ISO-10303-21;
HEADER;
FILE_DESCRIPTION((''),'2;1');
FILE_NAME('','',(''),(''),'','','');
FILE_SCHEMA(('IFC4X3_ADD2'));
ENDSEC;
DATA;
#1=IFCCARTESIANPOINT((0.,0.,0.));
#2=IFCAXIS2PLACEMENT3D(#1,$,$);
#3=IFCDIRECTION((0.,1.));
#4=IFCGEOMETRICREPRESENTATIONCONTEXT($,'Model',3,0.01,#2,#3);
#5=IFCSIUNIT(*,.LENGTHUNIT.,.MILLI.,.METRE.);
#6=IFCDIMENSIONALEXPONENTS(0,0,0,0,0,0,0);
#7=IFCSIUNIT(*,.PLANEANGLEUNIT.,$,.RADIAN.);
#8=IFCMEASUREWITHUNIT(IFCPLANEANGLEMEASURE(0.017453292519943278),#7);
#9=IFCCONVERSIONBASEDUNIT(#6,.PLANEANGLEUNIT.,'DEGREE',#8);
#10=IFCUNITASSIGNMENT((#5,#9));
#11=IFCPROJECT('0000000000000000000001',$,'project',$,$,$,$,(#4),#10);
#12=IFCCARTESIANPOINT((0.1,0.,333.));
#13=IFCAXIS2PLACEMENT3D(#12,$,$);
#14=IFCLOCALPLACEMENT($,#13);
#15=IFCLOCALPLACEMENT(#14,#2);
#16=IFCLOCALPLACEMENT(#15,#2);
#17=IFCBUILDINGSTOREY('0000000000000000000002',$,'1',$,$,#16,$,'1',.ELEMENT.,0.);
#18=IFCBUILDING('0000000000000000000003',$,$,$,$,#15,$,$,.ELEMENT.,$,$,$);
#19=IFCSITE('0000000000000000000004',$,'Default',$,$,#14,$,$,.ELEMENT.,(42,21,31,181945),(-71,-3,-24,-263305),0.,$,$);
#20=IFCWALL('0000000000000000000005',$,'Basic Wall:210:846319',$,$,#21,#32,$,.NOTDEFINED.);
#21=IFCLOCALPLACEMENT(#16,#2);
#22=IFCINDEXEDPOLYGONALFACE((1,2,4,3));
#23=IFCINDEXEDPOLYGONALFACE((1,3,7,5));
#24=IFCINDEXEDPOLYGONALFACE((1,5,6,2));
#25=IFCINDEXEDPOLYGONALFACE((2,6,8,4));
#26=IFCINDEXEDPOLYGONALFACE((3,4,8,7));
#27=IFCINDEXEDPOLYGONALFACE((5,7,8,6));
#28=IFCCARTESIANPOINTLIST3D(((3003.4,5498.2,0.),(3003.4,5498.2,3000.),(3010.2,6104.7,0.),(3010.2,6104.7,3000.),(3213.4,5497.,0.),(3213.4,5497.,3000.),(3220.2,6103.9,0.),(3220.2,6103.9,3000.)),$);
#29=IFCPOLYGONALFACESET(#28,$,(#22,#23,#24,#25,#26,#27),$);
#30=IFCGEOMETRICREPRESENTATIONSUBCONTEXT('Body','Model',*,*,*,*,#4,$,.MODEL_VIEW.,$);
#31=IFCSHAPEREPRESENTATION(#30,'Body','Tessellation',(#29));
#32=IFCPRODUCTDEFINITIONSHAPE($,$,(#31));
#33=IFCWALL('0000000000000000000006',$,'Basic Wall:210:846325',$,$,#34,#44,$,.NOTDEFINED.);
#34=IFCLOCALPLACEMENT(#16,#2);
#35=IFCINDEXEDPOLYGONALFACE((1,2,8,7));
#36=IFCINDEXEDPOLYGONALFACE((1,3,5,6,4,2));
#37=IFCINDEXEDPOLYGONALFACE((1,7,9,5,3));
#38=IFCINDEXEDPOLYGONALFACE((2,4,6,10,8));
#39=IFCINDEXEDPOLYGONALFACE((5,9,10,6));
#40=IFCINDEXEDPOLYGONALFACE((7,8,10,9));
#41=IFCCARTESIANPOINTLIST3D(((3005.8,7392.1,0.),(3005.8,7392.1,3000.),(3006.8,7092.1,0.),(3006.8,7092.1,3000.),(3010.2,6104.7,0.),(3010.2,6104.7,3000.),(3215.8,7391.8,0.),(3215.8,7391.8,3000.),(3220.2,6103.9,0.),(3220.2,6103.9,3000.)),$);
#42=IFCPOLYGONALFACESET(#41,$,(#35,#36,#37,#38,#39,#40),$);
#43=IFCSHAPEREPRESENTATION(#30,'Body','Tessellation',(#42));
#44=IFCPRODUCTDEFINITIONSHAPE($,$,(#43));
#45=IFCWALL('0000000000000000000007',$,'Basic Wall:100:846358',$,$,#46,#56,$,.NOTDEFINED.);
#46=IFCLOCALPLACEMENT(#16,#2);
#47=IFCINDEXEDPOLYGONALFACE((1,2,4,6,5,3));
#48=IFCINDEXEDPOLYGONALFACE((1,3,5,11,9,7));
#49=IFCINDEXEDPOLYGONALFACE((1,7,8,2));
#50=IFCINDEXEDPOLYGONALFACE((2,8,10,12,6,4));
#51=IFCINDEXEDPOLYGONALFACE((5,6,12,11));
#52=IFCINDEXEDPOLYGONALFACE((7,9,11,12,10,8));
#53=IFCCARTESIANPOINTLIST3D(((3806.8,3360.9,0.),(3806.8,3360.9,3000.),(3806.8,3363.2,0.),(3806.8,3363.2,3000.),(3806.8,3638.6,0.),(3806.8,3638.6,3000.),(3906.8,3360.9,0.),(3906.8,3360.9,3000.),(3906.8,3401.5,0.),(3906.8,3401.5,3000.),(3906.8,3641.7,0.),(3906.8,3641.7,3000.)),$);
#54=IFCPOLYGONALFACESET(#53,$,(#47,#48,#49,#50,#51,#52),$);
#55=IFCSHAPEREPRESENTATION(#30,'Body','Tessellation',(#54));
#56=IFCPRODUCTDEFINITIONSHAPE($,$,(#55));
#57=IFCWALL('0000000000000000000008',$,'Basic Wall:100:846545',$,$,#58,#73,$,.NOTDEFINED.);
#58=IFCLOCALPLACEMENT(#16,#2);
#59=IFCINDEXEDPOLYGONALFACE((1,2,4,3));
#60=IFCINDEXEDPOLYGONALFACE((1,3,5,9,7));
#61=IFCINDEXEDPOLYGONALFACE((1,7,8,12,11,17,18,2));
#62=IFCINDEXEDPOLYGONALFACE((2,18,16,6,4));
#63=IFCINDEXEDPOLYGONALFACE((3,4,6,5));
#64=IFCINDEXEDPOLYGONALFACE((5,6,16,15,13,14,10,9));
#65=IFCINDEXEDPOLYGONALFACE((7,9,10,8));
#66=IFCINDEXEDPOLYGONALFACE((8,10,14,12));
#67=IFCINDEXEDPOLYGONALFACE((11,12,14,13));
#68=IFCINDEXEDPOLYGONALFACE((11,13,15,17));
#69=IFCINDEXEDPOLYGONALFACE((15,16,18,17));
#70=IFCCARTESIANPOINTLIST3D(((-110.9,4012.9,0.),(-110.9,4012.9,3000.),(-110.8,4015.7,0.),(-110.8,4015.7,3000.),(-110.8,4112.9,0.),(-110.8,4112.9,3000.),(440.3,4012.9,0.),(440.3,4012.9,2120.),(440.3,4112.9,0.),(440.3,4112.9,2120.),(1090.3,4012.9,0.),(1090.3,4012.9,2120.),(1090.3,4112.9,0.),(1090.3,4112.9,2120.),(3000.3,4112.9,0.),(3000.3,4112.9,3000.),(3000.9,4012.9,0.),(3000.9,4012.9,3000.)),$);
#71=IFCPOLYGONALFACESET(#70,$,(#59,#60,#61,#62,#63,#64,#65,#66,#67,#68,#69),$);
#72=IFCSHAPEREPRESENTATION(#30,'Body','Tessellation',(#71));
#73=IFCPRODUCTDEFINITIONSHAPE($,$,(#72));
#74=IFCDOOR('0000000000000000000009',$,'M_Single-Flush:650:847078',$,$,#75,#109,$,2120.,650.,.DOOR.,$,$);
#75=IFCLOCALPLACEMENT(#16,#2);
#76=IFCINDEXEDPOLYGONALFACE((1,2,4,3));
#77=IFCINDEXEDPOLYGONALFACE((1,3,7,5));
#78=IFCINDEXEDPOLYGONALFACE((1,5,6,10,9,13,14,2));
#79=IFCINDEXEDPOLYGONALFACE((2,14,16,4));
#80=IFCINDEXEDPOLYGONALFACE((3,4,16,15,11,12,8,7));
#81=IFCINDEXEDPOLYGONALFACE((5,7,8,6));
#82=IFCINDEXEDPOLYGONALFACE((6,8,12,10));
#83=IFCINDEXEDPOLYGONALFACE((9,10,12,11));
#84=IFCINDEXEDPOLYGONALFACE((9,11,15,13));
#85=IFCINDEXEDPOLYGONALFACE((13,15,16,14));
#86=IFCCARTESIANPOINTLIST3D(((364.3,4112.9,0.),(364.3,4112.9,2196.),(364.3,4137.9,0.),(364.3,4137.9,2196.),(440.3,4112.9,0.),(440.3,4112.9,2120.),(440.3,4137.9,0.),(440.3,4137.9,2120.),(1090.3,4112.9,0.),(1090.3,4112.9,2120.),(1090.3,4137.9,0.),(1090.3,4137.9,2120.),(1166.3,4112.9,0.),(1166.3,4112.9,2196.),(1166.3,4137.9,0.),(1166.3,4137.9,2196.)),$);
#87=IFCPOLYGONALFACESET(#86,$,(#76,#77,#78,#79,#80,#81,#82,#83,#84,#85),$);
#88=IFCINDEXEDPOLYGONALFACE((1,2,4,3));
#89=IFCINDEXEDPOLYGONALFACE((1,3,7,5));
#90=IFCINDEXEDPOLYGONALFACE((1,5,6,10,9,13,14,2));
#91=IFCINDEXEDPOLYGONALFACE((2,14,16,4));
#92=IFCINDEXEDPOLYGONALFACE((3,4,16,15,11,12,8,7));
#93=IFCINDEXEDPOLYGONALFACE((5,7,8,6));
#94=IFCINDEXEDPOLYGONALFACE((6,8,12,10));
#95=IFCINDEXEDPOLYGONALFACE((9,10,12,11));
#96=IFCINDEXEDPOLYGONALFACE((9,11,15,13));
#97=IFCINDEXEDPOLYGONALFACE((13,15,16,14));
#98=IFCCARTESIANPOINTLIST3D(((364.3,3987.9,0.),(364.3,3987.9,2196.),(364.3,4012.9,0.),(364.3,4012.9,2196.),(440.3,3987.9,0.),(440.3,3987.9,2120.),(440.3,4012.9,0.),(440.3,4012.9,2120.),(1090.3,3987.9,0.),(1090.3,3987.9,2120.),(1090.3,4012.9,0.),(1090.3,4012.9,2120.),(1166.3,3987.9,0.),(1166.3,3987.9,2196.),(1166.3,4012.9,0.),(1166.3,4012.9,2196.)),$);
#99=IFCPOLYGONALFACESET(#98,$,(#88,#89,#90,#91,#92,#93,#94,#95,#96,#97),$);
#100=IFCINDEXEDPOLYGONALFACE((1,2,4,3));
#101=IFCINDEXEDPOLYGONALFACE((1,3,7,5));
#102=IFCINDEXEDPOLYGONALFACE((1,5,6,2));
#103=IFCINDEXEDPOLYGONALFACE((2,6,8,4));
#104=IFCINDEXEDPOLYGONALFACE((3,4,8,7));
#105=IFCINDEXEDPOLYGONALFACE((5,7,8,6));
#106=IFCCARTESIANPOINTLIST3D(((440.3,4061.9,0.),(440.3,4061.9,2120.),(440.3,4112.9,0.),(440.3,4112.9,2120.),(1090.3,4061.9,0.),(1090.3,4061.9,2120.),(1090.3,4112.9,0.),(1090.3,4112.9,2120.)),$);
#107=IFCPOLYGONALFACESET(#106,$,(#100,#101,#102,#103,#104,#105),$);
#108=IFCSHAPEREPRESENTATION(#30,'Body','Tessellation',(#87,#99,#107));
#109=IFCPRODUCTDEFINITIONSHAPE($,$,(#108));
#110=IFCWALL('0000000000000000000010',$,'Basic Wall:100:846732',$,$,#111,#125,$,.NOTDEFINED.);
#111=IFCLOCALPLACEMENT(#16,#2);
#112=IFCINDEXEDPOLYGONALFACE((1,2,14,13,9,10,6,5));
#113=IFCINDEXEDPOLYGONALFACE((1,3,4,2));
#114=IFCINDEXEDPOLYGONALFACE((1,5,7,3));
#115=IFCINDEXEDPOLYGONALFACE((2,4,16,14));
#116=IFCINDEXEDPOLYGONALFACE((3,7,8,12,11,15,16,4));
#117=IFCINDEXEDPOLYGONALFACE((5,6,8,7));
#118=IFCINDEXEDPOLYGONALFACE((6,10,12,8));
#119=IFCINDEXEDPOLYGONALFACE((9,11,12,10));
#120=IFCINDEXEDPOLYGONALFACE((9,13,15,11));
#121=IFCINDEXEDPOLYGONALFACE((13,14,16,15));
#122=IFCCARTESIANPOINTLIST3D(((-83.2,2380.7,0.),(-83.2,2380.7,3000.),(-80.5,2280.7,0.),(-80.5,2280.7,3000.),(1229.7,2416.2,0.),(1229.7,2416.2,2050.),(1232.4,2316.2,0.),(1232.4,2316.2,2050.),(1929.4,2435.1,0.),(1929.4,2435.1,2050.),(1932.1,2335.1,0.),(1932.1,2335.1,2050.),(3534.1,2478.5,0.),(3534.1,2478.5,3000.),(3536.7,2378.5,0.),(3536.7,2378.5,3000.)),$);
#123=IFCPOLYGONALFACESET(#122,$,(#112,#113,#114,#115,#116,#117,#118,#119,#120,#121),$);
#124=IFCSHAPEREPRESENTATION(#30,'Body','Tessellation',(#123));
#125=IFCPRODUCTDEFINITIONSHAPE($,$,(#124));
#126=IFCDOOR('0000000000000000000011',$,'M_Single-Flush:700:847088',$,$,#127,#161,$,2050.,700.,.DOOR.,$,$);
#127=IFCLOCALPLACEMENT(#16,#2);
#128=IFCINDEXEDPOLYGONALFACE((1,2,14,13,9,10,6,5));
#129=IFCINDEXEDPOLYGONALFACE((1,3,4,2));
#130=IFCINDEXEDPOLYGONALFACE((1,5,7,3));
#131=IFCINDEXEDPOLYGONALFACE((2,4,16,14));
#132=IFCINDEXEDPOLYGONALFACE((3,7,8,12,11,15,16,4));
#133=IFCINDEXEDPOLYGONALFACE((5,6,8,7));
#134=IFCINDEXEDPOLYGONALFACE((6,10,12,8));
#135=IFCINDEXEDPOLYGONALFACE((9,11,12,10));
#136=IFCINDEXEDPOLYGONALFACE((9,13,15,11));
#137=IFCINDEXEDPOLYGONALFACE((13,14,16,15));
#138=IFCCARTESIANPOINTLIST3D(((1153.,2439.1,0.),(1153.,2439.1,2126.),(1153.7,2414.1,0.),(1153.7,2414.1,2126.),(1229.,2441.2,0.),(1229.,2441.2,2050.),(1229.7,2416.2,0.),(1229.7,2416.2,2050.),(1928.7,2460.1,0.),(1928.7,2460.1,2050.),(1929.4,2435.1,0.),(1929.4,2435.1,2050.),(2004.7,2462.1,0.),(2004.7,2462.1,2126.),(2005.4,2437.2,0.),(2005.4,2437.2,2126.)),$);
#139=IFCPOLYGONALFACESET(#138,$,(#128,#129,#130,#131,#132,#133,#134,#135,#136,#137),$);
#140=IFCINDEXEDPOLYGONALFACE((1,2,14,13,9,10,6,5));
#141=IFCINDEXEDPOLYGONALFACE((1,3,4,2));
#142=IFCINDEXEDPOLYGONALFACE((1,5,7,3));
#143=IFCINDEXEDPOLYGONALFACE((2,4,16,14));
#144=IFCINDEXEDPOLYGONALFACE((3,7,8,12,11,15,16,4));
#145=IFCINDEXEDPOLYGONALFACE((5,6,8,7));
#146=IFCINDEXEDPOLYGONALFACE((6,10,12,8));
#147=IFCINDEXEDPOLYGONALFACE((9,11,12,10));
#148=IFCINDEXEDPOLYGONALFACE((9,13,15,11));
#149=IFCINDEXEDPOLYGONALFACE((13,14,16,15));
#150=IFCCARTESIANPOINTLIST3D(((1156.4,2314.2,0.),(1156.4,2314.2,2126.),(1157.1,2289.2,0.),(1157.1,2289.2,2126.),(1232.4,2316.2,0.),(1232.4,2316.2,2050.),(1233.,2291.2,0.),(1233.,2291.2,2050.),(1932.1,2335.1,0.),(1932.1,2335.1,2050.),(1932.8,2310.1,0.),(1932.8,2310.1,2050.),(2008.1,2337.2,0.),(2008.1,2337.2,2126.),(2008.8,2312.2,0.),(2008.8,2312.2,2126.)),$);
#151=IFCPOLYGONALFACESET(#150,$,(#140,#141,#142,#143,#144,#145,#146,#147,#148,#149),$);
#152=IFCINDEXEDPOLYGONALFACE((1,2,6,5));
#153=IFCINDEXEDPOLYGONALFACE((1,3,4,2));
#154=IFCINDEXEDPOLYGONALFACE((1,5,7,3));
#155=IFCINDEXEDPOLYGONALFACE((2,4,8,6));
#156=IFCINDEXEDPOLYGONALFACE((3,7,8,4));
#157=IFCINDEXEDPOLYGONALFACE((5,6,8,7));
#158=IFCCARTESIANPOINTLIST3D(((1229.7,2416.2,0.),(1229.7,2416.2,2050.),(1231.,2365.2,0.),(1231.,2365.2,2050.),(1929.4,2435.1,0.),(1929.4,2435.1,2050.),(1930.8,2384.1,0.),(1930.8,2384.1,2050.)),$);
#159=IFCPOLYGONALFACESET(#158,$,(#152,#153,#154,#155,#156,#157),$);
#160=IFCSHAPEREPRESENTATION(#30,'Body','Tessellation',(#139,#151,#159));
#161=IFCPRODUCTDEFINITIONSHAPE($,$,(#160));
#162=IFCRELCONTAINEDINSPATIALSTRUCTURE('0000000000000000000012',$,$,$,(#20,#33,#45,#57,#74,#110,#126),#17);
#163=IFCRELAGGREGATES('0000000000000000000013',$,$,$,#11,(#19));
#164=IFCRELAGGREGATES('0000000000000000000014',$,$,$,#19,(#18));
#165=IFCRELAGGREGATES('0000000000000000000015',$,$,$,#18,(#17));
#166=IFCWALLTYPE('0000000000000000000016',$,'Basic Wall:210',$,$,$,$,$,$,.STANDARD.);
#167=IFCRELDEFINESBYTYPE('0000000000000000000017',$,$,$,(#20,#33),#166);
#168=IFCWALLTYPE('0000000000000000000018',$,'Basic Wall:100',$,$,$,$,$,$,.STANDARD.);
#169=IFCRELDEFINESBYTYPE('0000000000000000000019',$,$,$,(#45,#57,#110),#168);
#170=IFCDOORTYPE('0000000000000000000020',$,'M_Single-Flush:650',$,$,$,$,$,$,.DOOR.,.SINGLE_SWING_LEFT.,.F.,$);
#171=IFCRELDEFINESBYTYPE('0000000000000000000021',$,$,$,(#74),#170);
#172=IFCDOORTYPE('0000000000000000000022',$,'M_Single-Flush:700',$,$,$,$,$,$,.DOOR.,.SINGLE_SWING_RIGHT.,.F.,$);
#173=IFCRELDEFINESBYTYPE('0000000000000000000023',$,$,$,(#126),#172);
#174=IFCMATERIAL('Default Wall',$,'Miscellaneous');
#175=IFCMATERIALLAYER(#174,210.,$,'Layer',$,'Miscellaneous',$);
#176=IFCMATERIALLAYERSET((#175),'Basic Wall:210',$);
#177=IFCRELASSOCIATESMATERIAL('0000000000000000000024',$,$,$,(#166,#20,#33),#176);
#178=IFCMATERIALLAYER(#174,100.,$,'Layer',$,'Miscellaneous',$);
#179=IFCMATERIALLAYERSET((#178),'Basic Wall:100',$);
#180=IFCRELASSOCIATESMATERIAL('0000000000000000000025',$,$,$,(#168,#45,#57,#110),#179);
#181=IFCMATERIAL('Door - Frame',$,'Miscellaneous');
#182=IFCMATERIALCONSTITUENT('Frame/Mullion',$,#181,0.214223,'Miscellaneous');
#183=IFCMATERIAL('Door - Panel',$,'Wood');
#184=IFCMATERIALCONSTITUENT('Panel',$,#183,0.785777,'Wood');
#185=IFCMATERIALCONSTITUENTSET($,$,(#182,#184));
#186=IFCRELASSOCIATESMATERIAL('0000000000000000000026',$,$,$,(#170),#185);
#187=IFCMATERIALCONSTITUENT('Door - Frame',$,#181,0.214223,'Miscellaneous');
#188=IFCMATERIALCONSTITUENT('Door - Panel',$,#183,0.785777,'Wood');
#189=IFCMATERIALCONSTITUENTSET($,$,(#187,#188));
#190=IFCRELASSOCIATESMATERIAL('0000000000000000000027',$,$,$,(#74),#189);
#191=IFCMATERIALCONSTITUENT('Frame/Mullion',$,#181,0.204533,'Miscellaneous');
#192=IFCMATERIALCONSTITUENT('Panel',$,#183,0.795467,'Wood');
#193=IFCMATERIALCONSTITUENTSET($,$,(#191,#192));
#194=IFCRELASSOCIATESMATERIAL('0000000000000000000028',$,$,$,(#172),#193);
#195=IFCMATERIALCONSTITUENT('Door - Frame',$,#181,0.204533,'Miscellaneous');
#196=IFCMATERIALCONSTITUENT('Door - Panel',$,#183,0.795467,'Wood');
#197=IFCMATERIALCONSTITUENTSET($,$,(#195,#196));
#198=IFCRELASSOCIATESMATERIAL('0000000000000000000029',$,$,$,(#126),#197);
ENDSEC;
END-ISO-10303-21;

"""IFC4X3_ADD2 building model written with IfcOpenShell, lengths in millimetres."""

from ifc_helpers import new_model, entity, si_unit, converted_unit, direction, frame, frame_2d, origin, origin_2d_with_axis, place, context, subcontext, project, spatial, polyline, rectangle, outline, extrude, source, transform, mapped, material, layer, layer_set, constituent, constituent_set, type_object, type_shapes, element, fill, save


model = new_model("IFC4X3_ADD2")

# Units and contexts
model_context = context("Model", 3, precision=0.01, world=origin(), true_north=direction((0.0, 1.0)))
body_context = subcontext(model_context, "Body", "Model", "MODEL_VIEW")
ifc_project = project(units=[si_unit("LENGTHUNIT", "METRE", prefix="MILLI"), converted_unit("PLANEANGLEUNIT", "DEGREE", entity("IfcPlaneAngleMeasure", 0.017453292519943278), si_unit("PLANEANGLEUNIT", "RADIAN"), dimensions=[0, 0, 0, 0, 0, 0, 0])], contexts=[model_context])

# Site, building, storey
site_placement = place(None, frame((0.1, 0.0, 333.0)))
site = spatial("IfcSite", under=ifc_project, at=site_placement, Name="Default", CompositionType="ELEMENT", RefLatitude=(42, 21, 31, 181945), RefLongitude=(-71, -3, -24, -263305), RefElevation=0.0)
building_placement = place(site_placement, origin())
building = spatial("IfcBuilding", under=site, at=building_placement, CompositionType="ELEMENT")
storey_placement = place(building_placement, origin())
storey = spatial("IfcBuildingStorey", under=building, at=storey_placement, Name="1", LongName="1", CompositionType="ELEMENT", Elevation=0.0)

# Shared definitions
ifc_material_1 = material(Name="Default Wall", Category="Miscellaneous")

# Walls
ifc_layer_1 = layer(ifc_material_1, 210.0, Name="Layer", Category="Miscellaneous")
ifc_layer_set_1 = layer_set([ifc_layer_1], Name="Basic Wall:210")
wall_type_1 = type_object("IfcWallType", Name="Basic Wall:210", PredefinedType="STANDARD", material=ifc_layer_set_1)
wall_1_placement = place(storey_placement, frame((3115.2, 6105.1, 0.0), z_axis=(0.0, 0.0, 1.0), x_axis=(-0.011193, -0.999937, 0.0)))
element("IfcWall", 1, at=wall_1_placement, inside=storey, type_object=wall_type_1, material=ifc_layer_set_1, Name="Basic Wall:210:846319", PredefinedType="NOTDEFINED", context=body_context, shape_type="SweptSolid", body=[
    extrude(outline(polyline([(608.1, -105.0), (606.9, 105.0), (0.0, 105.0), (1.5, -105.0), (608.1, -105.0)])), origin(), (0.0, 0.0, 1.0), 3000.0),
])
wall_2_placement = place(storey_placement, frame((3110.8, 7392.5, 0.0), z_axis=(0.0, 0.0, 1.0), x_axis=(0.003397, -0.999994, 0.0)))
element("IfcWall", 2, at=wall_2_placement, inside=storey, type_object=wall_type_1, material=ifc_layer_set_1, Name="Basic Wall:210:846325", PredefinedType="NOTDEFINED", context=body_context, shape_type="SweptSolid", body=[
    extrude(outline(polyline([(1287.4, -105.0), (1288.9, 105.0), (1.0, 105.0), (0.0, -105.0), (300.0, -105.0), (1287.4, -105.0)])), origin(), (0.0, 0.0, 1.0), 3000.0),
])
ifc_layer_2 = layer(ifc_material_1, 100.0, Name="Layer", Category="Miscellaneous")
ifc_layer_set_2 = layer_set([ifc_layer_2], Name="Basic Wall:100")
wall_type_2 = type_object("IfcWallType", Name="Basic Wall:100", PredefinedType="STANDARD", material=ifc_layer_set_2)
wall_3_placement = place(storey_placement, frame((3856.8, 3360.9, 0.0), z_axis=(0.0, 0.0, 1.0), x_axis=(0.0, 1.0, 0.0)))
element("IfcWall", 3, at=wall_3_placement, inside=storey, type_object=wall_type_2, material=ifc_layer_set_2, Name="Basic Wall:100:846358", PredefinedType="NOTDEFINED", context=body_context, shape_type="SweptSolid", body=[
    extrude(outline(polyline([(280.7, -50.0), (277.6, 50.0), (2.3, 50.0), (0.0, 50.0), (0.0, -50.0), (40.6, -50.0), (280.7, -50.0)])), origin(), (0.0, 0.0, 1.0), 3000.0),
])

# Walls, openings, doors
wall_4_placement = place(storey_placement, frame((3000.9, 4062.9, 0.0), z_axis=(0.0, 0.0, 1.0), x_axis=(-1.0, 0.0, 0.0)))
wall_4 = element("IfcWall", 4, at=wall_4_placement, inside=storey, type_object=wall_type_2, material=ifc_layer_set_2, Name="Basic Wall:100:846545", PredefinedType="NOTDEFINED", context=body_context, shape_type="SweptSolid", body=[
    extrude(outline(polyline([(0.6, -50.0), (3111.7, -50.0), (3111.7, 47.1), (3111.8, 50.0), (0.0, 50.0), (0.6, -50.0)])), origin(), (0.0, 0.0, 1.0), 3000.0),
])
opening_1_placement = place(wall_4_placement, frame((2560.6, 50.0, 0.0)))
opening_1 = element("IfcOpeningElement", 5, at=opening_1_placement, cuts=wall_4, PredefinedType="OPENING", context=body_context, shape_type="SweptSolid", body=[
    extrude(rectangle(XDim=650.0, YDim=2120.0, at=frame_2d((1060.0, 325.0), x_axis=(0.0, -1.0))), frame((0.0, 0.0, 0.0), z_axis=(0.0, -1.0, 0.0), x_axis=(0.0, 0.0, 1.0)), (0.0, 0.0, 1.0), 100.0),
])
ifc_material_2 = material(Name="Door - Frame", Category="Miscellaneous")
ifc_constituent_1 = constituent(ifc_material_2, Name="Door - Frame", Category="Miscellaneous", fraction=0.214223)
ifc_material_3 = material(Name="Door - Panel", Category="Wood")
ifc_constituent_2 = constituent(ifc_material_3, Name="Door - Panel", Category="Wood", fraction=0.785777)
ifc_constituent_set_1 = constituent_set(constituents=[ifc_constituent_1, ifc_constituent_2])
ifc_constituent_3 = constituent(ifc_material_2, Name="Frame/Mullion", Category="Miscellaneous", fraction=0.214223)
ifc_constituent_4 = constituent(ifc_material_3, Name="Panel", Category="Wood", fraction=0.785777)
ifc_constituent_set_2 = constituent_set(constituents=[ifc_constituent_3, ifc_constituent_4])
door_type_1 = type_object("IfcDoorType", Name="M_Single-Flush:650", OperationType="SINGLE_SWING_LEFT", ParameterTakesPrecedence=False, PredefinedType="DOOR", material=ifc_constituent_set_2)
shared_shape_1 = source(origin(), body_context, "Body", "SweptSolid", [
    extrude(outline(polyline([(-401.0, -1117.0), (401.0, -1117.0), (401.0, 1079.0), (325.0, 1079.0), (325.0, -1041.0), (-325.0, -1041.0), (-325.0, 1079.0), (-401.0, 1079.0), (-401.0, -1117.0)])), frame((325.0, 125.0, 1079.0), z_axis=(0.0, -1.0, 0.0), x_axis=(-1.0, 0.0, 0.0)), (0.0, 0.0, 1.0), 25.0),
    extrude(outline(polyline([(-1117.0, -401.0), (1079.0, -401.0), (1079.0, -325.0), (-1041.0, -325.0), (-1041.0, 325.0), (1079.0, 325.0), (1079.0, 401.0), (-1117.0, 401.0), (-1117.0, -401.0)])), frame((325.0, 0.0, 1079.0), z_axis=(0.0, -1.0, 0.0), x_axis=(0.0, 0.0, -1.0)), (0.0, 0.0, 1.0), 25.0),
    extrude(rectangle(XDim=650.0, YDim=51.0, at=origin_2d_with_axis()), frame((325.0, 74.5, 0.0)), (0.0, 0.0, 1.0), 2120.0),
])
type_shapes(door_type_1, [shared_shape_1])
door_1_placement = place(opening_1_placement, frame((0.0, 0.0, 0.0), z_axis=(0.0, 0.0, 1.0), x_axis=(-1.0, 0.0, 0.0)))
door_1 = element("IfcDoor", 6, at=door_1_placement, inside=storey, type_object=door_type_1, material=ifc_constituent_set_1, Name="M_Single-Flush:650:847078", OverallHeight=2120.0, OverallWidth=650.0, PredefinedType="DOOR", context=body_context, shape_type="MappedRepresentation", body=[
    mapped(shared_shape_1, transform((0.0, 0.0, 0.0), scale=1.0)),
])
fill(opening_1, door_1)
wall_5_placement = place(storey_placement, frame((-81.8, 2330.7, 0.0), z_axis=(0.0, 0.0, 1.0), x_axis=(0.999635, 0.027022, 0.0)))
wall_5 = element("IfcWall", 7, at=wall_5_placement, inside=storey, type_object=wall_type_2, material=ifc_layer_set_2, Name="Basic Wall:100:846732", PredefinedType="NOTDEFINED", context=body_context, shape_type="SweptSolid", body=[
    extrude(outline(polyline([(0.0, -50.0), (3618.5, -50.0), (3618.6, 50.0), (3187.5, 50.0), (3087.5, 50.0), (0.0, 50.0), (0.0, -50.0)])), origin(), (0.0, 0.0, 1.0), 3000.0),
])
opening_2_placement = place(wall_5_placement, frame((1313.3, -50.0, 0.0)))
opening_2 = element("IfcOpeningElement", 8, at=opening_2_placement, cuts=wall_5, PredefinedType="OPENING", context=body_context, shape_type="SweptSolid", body=[
    extrude(rectangle(XDim=700.0, YDim=2050.0, at=frame_2d((1025.0, 350.0), x_axis=(0.0, 1.0))), frame((0.0, 0.0, 0.0), z_axis=(0.0, 1.0, 0.0), x_axis=(0.0, 0.0, 1.0)), (0.0, 0.0, 1.0), 100.0),
])
ifc_constituent_5 = constituent(ifc_material_2, Name="Door - Frame", Category="Miscellaneous", fraction=0.204533)
ifc_constituent_6 = constituent(ifc_material_3, Name="Door - Panel", Category="Wood", fraction=0.795467)
ifc_constituent_set_3 = constituent_set(constituents=[ifc_constituent_5, ifc_constituent_6])
ifc_constituent_7 = constituent(ifc_material_2, Name="Frame/Mullion", Category="Miscellaneous", fraction=0.204533)
ifc_constituent_8 = constituent(ifc_material_3, Name="Panel", Category="Wood", fraction=0.795467)
ifc_constituent_set_4 = constituent_set(constituents=[ifc_constituent_7, ifc_constituent_8])
door_type_2 = type_object("IfcDoorType", Name="M_Single-Flush:700", OperationType="SINGLE_SWING_RIGHT", ParameterTakesPrecedence=False, PredefinedType="DOOR", material=ifc_constituent_set_4)
shared_shape_2 = source(origin(), body_context, "Body", "SweptSolid", [
    extrude(outline(polyline([(-426.0, -1082.0), (426.0, -1082.0), (426.0, 1044.0), (350.0, 1044.0), (350.0, -1006.0), (-350.0, -1006.0), (-350.0, 1044.0), (-426.0, 1044.0), (-426.0, -1082.0)])), frame((350.0, 100.0, 1044.0), z_axis=(0.0, 1.0, 0.0), x_axis=(1.0, 0.0, 0.0)), (0.0, 0.0, 1.0), 25.0),
    extrude(outline(polyline([(-1082.0, -426.0), (1044.0, -426.0), (1044.0, -350.0), (-1006.0, -350.0), (-1006.0, 350.0), (1044.0, 350.0), (1044.0, 426.0), (-1082.0, 426.0), (-1082.0, -426.0)])), frame((350.0, -25.0, 1044.0), z_axis=(0.0, 1.0, 0.0), x_axis=(0.0, 0.0, -1.0)), (0.0, 0.0, 1.0), 25.0),
    extrude(rectangle(XDim=51.0, YDim=700.0, at=origin_2d_with_axis()), frame((350.0, 74.5, 0.0), z_axis=(0.0, 0.0, 1.0), x_axis=(0.0, 1.0, 0.0)), (0.0, 0.0, 1.0), 2050.0),
])
type_shapes(door_type_2, [shared_shape_2])
door_2_placement = place(opening_2_placement, origin())
door_2 = element("IfcDoor", 9, at=door_2_placement, inside=storey, type_object=door_type_2, material=ifc_constituent_set_3, Name="M_Single-Flush:700:847088", OverallHeight=2050.0, OverallWidth=700.0, PredefinedType="DOOR", context=body_context, shape_type="MappedRepresentation", body=[
    mapped(shared_shape_2, transform((0.0, 0.0, 0.0), scale=1.0)),
])
fill(opening_2, door_2)

save(model, "model.ifc")
